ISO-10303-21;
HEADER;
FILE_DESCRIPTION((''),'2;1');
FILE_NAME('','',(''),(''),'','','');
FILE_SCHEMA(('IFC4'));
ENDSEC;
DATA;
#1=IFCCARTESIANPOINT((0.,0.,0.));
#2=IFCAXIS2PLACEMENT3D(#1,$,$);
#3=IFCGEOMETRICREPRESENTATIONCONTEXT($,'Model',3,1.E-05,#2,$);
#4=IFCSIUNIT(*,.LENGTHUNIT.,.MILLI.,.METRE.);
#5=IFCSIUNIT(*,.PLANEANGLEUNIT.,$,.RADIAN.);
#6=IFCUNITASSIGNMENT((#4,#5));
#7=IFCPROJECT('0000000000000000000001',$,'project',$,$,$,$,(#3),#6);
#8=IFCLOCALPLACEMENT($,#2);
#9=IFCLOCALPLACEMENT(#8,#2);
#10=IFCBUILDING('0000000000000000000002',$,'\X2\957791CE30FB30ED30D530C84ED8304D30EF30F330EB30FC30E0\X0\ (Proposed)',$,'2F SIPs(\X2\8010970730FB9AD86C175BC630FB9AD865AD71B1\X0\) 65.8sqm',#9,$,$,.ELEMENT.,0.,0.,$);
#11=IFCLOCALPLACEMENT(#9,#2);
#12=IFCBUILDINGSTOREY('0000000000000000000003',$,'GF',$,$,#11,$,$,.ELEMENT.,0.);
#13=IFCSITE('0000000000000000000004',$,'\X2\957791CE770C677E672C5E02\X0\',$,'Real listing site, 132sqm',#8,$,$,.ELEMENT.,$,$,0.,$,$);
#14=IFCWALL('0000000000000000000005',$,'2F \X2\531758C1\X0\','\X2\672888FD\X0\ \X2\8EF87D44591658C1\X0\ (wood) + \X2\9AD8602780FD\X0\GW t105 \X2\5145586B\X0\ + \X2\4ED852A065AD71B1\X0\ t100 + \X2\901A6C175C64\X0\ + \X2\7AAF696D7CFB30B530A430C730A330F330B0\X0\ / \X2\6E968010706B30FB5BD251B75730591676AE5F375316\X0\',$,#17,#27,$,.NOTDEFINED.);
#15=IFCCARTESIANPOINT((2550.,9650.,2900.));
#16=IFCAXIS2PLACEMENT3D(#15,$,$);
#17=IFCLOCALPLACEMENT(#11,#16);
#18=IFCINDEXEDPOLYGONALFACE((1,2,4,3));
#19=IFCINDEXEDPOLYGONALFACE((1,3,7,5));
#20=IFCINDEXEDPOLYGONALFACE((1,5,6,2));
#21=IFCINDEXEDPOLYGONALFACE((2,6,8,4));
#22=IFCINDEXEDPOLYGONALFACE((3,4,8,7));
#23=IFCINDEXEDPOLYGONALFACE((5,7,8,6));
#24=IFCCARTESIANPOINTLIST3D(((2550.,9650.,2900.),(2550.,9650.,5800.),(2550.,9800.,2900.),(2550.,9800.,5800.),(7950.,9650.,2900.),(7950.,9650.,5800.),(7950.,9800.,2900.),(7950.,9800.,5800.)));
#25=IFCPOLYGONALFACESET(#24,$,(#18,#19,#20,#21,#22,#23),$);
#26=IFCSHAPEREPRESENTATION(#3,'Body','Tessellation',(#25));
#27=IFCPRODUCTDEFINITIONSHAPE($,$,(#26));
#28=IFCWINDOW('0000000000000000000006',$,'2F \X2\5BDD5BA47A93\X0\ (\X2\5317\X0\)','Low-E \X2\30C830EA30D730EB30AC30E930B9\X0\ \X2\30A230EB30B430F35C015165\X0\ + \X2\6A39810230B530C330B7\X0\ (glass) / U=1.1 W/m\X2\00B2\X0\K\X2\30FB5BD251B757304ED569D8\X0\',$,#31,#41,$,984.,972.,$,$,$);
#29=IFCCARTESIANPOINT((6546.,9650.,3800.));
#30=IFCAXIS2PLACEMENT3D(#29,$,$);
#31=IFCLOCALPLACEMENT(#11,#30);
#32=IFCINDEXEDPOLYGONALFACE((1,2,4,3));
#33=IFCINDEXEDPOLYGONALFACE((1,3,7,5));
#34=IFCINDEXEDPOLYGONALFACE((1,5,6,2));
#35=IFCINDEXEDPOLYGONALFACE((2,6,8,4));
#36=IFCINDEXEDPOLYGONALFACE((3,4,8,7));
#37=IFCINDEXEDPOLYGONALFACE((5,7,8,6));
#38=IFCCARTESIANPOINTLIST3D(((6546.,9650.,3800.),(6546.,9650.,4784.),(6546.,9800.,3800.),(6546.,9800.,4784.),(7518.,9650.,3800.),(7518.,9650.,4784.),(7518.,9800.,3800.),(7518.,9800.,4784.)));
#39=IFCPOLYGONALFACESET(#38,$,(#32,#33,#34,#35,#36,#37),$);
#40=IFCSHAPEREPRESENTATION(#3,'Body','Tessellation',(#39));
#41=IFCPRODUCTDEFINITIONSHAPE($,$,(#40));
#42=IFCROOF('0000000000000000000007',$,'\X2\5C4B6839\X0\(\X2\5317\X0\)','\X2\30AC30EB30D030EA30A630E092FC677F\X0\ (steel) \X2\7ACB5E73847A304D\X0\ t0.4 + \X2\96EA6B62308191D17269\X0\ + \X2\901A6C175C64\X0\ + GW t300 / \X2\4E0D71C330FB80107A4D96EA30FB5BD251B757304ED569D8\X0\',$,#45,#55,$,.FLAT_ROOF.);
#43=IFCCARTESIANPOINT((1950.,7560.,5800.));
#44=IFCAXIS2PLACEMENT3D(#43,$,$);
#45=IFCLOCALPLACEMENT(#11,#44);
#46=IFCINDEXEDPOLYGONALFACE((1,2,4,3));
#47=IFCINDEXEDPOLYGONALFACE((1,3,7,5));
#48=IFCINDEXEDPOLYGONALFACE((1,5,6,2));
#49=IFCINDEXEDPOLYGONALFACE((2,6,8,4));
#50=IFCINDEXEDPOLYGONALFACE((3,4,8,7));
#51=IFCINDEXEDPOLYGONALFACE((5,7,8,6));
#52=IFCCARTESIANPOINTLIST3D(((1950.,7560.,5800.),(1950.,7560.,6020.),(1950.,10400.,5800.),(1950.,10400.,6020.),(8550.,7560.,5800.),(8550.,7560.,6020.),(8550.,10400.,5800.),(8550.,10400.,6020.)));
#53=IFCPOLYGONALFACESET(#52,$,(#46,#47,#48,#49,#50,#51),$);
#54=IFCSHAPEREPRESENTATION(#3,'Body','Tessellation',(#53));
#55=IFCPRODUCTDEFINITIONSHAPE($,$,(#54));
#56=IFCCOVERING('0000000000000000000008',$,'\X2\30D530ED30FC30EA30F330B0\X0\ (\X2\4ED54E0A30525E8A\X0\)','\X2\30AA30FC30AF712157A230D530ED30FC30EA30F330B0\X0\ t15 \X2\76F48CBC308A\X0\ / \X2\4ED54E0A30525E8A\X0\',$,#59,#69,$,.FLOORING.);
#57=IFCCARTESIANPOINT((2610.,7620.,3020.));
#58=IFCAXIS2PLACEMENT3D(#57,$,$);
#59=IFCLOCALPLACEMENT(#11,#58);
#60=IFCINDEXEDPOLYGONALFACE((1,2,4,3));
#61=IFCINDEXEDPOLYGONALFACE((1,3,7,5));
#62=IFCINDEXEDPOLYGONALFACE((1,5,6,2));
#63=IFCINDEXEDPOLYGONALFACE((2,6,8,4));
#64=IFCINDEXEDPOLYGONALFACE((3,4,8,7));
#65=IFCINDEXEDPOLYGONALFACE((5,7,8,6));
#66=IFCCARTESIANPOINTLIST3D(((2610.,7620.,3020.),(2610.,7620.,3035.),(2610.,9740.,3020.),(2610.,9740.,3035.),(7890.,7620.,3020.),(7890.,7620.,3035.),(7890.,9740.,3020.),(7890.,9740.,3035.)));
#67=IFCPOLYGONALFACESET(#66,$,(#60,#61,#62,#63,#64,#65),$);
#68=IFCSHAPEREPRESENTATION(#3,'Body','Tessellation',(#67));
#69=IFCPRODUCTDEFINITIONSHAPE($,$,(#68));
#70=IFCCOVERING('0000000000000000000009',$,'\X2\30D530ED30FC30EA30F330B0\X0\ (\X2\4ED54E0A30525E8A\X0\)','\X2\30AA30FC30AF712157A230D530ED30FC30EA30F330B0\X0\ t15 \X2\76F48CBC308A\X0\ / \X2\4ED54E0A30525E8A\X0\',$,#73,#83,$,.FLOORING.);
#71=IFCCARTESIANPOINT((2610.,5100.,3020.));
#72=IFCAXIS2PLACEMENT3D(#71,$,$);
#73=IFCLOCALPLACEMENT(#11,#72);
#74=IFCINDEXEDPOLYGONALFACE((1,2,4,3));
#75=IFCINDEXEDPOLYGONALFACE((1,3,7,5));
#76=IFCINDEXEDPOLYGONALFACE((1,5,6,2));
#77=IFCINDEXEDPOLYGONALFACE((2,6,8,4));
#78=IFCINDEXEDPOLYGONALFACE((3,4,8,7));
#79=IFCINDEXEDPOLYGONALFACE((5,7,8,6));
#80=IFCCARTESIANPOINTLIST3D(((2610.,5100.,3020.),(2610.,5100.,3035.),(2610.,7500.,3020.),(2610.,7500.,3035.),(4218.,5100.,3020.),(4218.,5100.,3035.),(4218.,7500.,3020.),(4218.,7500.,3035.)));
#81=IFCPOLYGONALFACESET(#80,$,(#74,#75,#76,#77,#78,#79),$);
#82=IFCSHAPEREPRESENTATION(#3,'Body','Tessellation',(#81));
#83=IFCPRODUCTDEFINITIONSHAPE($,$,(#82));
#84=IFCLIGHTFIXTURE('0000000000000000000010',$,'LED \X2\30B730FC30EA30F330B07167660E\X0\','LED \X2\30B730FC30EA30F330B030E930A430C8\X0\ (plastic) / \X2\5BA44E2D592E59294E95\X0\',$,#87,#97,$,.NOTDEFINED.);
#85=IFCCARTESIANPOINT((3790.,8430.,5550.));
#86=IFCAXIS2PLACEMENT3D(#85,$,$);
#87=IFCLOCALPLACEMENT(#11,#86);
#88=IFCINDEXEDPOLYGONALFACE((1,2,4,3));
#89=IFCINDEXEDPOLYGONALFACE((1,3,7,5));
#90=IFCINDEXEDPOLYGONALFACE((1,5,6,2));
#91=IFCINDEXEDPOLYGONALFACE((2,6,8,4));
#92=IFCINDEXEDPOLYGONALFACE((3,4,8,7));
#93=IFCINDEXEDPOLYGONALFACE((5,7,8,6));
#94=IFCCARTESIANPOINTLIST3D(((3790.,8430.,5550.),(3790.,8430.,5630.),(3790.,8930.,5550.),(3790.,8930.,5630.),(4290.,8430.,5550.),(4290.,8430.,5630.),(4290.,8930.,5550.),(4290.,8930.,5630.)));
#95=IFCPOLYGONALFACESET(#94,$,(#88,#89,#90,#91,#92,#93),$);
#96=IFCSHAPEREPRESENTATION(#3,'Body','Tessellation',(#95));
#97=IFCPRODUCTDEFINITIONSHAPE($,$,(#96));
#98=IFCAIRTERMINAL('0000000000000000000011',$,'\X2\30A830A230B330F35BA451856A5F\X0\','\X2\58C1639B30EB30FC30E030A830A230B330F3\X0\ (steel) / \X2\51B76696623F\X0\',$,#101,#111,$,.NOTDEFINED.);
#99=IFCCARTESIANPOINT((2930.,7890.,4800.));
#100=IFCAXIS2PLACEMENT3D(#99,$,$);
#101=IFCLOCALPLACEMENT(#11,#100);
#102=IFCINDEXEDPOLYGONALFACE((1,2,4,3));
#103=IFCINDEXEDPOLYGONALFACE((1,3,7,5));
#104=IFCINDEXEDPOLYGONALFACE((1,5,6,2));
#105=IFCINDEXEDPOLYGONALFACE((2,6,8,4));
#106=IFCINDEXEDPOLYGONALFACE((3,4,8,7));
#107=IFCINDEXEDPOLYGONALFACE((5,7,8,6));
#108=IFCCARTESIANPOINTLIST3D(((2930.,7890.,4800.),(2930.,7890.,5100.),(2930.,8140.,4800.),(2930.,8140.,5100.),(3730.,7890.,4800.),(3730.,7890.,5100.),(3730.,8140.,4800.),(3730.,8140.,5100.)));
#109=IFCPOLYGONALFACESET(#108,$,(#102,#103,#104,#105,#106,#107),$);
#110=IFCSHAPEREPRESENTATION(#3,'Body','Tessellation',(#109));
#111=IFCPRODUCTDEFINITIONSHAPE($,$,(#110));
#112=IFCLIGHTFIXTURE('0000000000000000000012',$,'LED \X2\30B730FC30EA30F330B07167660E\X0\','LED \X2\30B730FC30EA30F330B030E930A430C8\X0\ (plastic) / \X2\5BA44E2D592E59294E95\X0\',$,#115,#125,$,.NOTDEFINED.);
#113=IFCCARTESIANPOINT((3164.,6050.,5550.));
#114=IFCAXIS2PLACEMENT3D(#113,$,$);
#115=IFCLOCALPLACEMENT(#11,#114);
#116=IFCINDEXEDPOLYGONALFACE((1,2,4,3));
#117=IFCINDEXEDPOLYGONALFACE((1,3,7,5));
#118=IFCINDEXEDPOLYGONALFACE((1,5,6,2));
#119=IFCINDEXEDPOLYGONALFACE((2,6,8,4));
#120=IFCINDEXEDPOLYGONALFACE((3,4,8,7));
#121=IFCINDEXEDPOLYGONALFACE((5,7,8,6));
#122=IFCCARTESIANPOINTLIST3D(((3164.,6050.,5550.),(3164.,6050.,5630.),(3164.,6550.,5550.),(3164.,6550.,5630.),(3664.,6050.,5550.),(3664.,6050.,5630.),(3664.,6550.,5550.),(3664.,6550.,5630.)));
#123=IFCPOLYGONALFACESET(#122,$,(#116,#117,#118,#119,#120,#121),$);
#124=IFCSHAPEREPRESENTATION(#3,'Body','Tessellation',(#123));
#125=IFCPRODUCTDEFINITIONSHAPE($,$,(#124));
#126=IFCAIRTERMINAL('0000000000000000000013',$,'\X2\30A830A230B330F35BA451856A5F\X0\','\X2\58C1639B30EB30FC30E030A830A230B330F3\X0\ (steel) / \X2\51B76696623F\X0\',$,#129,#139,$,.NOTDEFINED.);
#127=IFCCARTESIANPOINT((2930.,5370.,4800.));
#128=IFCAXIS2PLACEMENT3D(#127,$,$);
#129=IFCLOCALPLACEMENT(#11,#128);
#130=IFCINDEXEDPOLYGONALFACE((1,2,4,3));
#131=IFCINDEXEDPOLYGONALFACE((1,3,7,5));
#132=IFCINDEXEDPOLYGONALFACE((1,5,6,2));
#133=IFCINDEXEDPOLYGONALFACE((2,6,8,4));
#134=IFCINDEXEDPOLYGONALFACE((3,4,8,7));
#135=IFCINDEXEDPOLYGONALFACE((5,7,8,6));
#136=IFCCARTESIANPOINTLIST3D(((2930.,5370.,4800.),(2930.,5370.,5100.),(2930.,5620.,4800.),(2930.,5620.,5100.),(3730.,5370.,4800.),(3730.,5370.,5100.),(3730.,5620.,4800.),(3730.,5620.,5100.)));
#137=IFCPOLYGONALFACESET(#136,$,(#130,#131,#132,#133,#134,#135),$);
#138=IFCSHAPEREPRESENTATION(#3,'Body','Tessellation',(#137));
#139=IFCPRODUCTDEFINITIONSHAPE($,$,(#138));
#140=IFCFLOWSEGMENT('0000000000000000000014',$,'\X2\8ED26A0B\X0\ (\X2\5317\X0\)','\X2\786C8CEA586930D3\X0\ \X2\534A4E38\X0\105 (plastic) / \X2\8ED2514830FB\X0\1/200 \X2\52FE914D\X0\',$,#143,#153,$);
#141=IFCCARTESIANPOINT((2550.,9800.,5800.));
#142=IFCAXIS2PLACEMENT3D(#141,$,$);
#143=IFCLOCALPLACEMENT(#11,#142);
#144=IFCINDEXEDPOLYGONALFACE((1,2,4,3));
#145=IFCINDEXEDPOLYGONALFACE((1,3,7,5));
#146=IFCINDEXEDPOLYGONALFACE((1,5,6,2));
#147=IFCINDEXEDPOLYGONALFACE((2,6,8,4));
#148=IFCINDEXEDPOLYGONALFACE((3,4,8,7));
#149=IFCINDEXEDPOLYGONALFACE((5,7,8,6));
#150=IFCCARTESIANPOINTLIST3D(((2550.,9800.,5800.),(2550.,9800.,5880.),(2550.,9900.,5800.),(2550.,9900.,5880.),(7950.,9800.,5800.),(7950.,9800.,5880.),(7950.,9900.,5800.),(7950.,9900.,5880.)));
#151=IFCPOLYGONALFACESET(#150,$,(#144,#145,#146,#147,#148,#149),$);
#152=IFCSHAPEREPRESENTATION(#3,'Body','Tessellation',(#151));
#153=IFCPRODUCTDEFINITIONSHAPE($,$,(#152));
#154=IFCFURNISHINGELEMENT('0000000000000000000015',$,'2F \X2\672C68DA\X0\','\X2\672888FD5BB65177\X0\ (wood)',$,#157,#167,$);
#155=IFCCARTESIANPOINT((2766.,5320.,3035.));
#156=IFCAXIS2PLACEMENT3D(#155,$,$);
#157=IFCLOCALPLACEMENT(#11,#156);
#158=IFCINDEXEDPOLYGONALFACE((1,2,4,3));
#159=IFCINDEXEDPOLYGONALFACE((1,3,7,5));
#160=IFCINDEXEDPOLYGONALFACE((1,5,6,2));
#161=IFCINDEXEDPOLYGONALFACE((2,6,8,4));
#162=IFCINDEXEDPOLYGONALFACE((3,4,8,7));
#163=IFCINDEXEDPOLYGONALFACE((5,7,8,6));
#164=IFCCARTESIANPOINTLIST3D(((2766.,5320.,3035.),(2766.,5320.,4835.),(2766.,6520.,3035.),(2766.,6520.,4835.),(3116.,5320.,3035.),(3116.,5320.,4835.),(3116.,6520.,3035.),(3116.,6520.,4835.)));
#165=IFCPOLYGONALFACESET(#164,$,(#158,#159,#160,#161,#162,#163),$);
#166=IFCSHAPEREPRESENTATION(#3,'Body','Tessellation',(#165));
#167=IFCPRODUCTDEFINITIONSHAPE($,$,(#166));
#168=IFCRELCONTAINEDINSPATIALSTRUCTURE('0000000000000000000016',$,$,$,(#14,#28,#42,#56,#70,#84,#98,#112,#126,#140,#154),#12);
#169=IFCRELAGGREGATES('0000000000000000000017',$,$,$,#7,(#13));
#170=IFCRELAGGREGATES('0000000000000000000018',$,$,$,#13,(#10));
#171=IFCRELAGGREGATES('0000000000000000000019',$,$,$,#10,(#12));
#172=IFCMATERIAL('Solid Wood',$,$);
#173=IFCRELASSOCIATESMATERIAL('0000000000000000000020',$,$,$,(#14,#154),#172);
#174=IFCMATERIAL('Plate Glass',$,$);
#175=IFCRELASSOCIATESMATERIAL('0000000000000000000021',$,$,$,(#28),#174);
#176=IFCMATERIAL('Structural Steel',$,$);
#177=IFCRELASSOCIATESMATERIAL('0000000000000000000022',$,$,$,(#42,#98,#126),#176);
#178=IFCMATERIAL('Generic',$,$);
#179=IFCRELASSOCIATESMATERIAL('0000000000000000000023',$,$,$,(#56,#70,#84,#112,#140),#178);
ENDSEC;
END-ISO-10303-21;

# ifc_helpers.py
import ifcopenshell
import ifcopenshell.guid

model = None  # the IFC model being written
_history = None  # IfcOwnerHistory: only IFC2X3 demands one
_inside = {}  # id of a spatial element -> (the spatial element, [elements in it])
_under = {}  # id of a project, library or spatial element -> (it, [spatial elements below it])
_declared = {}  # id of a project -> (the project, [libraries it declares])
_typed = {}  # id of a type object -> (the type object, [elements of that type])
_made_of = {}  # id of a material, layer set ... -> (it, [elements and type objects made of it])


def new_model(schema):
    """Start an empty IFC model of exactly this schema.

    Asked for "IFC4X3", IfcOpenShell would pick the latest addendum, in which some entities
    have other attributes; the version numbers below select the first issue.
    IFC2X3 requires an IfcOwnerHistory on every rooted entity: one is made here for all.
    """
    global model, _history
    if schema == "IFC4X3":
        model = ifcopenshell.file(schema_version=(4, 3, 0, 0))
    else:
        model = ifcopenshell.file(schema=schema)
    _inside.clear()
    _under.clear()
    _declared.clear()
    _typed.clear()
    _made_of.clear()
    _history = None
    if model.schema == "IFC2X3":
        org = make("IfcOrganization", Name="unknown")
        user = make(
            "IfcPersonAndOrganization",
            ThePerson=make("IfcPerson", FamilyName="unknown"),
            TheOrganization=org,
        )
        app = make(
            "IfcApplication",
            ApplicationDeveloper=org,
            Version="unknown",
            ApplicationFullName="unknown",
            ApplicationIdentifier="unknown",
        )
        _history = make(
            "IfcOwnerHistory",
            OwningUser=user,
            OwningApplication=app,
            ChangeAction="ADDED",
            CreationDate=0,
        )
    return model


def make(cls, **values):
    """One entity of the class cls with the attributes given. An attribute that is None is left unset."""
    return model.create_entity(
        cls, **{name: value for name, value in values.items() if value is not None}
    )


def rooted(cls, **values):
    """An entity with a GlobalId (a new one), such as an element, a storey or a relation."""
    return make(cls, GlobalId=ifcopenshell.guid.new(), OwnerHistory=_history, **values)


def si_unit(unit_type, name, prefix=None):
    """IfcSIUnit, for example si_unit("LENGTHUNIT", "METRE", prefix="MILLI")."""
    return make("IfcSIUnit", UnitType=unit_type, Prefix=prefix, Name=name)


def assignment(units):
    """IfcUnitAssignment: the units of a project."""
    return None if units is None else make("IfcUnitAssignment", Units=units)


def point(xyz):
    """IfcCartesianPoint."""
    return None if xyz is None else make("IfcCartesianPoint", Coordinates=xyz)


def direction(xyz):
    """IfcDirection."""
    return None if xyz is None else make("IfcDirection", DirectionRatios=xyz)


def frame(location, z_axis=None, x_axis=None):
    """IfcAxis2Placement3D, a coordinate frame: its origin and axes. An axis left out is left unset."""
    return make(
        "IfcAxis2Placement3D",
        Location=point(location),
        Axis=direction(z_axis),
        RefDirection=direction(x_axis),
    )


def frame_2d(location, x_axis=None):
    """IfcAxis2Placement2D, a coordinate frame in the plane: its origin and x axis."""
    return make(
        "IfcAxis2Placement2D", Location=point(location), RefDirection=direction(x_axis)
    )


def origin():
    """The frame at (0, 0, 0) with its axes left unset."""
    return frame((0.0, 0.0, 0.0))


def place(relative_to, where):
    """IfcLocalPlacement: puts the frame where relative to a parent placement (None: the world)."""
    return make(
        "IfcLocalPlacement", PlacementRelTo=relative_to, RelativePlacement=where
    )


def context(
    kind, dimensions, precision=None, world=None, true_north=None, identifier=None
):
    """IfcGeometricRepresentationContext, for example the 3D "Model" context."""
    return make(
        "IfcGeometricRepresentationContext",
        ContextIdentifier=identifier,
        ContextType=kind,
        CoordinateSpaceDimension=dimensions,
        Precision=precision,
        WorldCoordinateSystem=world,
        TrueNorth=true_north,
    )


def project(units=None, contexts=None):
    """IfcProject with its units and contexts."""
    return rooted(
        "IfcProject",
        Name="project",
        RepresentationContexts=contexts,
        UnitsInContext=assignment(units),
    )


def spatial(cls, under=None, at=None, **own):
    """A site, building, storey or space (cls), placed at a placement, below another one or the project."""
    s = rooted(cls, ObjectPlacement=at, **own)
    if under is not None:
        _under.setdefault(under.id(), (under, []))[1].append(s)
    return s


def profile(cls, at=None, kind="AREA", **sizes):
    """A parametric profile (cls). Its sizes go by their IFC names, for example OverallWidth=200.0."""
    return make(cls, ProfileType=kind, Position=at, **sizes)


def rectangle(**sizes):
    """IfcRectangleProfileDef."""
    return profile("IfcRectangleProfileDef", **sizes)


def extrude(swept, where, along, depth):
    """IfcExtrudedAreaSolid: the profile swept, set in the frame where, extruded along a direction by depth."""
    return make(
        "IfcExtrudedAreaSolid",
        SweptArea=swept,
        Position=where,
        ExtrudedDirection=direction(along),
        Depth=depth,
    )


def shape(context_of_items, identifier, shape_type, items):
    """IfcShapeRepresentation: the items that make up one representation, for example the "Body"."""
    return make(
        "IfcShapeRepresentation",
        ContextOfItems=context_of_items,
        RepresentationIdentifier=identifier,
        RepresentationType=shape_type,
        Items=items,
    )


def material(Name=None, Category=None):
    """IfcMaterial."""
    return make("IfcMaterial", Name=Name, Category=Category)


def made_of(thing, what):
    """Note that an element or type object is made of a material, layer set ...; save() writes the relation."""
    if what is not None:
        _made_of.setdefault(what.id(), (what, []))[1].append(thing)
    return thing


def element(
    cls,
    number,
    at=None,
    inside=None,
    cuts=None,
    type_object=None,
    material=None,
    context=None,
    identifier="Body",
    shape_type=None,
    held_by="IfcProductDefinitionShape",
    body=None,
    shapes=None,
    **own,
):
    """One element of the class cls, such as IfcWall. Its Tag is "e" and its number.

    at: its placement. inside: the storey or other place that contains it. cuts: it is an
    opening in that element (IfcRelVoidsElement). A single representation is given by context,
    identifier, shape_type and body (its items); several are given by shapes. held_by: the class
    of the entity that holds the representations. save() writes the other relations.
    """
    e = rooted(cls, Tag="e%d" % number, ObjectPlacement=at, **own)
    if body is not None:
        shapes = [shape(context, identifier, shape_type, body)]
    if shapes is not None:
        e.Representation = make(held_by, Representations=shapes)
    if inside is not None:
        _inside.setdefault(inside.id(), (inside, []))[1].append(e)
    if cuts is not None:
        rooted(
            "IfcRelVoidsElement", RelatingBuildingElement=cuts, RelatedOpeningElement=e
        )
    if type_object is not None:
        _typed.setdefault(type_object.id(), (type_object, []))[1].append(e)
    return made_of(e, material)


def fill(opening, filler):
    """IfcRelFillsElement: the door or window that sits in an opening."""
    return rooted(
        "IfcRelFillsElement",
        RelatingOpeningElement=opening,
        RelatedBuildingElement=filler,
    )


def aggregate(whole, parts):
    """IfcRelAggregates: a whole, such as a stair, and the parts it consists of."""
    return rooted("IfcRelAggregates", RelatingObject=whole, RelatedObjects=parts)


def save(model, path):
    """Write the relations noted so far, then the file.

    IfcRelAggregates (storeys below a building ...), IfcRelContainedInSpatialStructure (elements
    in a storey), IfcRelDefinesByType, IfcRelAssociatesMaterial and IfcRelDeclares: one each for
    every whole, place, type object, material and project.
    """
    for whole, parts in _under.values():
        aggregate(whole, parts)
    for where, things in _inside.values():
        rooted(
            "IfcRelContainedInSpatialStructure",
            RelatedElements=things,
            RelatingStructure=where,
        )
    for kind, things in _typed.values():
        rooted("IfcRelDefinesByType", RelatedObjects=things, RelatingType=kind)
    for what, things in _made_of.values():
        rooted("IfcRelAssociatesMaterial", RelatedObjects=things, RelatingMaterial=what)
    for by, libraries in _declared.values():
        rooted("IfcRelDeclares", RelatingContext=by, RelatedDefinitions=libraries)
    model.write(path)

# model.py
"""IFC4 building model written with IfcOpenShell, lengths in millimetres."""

from ifc_helpers import new_model, si_unit, frame, frame_2d, origin, place, context, project, spatial, rectangle, extrude, material, element, fill, save


model = new_model("IFC4")

# Units and contexts
model_context = context("Model", 3, precision=1e-05, world=origin())
ifc_project = project(units=[si_unit("LENGTHUNIT", "METRE", prefix="MILLI"), si_unit("PLANEANGLEUNIT", "RADIAN")], contexts=[model_context])

# Site, building, storey
site_placement = place(None, origin())
site = spatial("IfcSite", under=ifc_project, at=site_placement, Name="長野県松本市", ObjectType="Real listing site, 132sqm", CompositionType="ELEMENT", RefElevation=0.0)
building_placement = place(site_placement, origin())
building = spatial("IfcBuilding", under=site, at=building_placement, Name="長野・ロフト付きワンルーム (Proposed)", ObjectType="2F SIPs(耐震・高気密・高断熱) 65.8sqm", CompositionType="ELEMENT", ElevationOfRefHeight=0.0, ElevationOfTerrain=0.0)
storey_placement = place(building_placement, origin())
storey = spatial("IfcBuildingStorey", under=building, at=storey_placement, Name="GF", CompositionType="ELEMENT", Elevation=0.0)

# Shared definitions
ifc_material_1 = material(Name="Solid Wood")

# Wall, opening, window
wall_placement = place(storey_placement, frame((2550.0, 9650.0, 2900.0)))
wall = element("IfcWall", 1, at=wall_placement, inside=storey, material=ifc_material_1, Name="2F 北壁", Description="木製 軸組外壁 (wood) + 高性能GW t105 充填 + 付加断熱 t100 + 通気層 + 窯業系サイディング / 準耐火・寒冷地外皮強化", PredefinedType="NOTDEFINED", context=model_context, shape_type="SweptSolid", body=[
    extrude(rectangle(XDim=5400.0, YDim=150.0, at=frame_2d((2700.0, 75.0))), frame((2550.0, 9650.0, 2900.0)), (0.0, 0.0, 1.0), 2900.0),
])
opening_placement = place(storey_placement, frame((6546.0, 9650.0, 3800.0)))
opening = element("IfcOpeningElement", 2, at=opening_placement, cuts=wall, PredefinedType="NOTDEFINED", context=model_context, shape_type="SweptSolid", body=[
    extrude(rectangle(XDim=972.0, YDim=150.0, at=frame_2d((486.0, 75.0))), frame((6546.0, 9650.0, 3800.0)), (0.0, 0.0, 1.0), 984.0),
])
ifc_material_2 = material(Name="Plate Glass")
window_placement = place(storey_placement, frame((6546.0, 9650.0, 3800.0)))
window = element("IfcWindow", 3, at=window_placement, inside=storey, material=ifc_material_2, Name="2F 寝室窓 (北)", Description="Low-E トリプルガラス アルゴン封入 + 樹脂サッシ (glass) / U=1.1 W/m²K・寒冷地仕様", OverallHeight=984.0, OverallWidth=972.0, context=model_context, shape_type="SweptSolid", body=[
    extrude(rectangle(XDim=972.0, YDim=150.0, at=frame_2d((486.0, 75.0))), frame((6546.0, 9650.0, 3800.0)), (0.0, 0.0, 1.0), 984.0),
])
fill(opening, window)

# Roof
ifc_material_3 = material(Name="Structural Steel")
for number, where, name in (
    (4, (1950.0, 7560.0, 5800.0), "屋根(北)"),
):
    element("IfcRoof", number, at=place(storey_placement, frame(where)), inside=storey, material=ifc_material_3, Name=name, Description="ガルバリウム鋼板 (steel) 立平葺き t0.4 + 雪止め金物 + 通気層 + GW t300 / 不燃・耐積雪・寒冷地仕様", PredefinedType="FLAT_ROOF", context=model_context, shape_type="SweptSolid", body=[
        extrude(rectangle(XDim=6600.0, YDim=2840.0, at=frame_2d((3300.0, 1420.0))), frame((1950.0, 7560.0, 5800.0)), (0.0, 0.0, 1.0), 220.0),
    ])

# Coverings
ifc_material_4 = material(Name="Generic")
covering_1_placement = place(storey_placement, frame((2610.0, 7620.0, 3020.0)))
element("IfcCovering", 5, at=covering_1_placement, inside=storey, material=ifc_material_4, Name="フローリング (仕上げ床)", Description="オーク無垢フローリング t15 直貼り / 仕上げ床", PredefinedType="FLOORING", context=model_context, shape_type="SweptSolid", body=[
    extrude(rectangle(XDim=5280.0, YDim=2120.0, at=frame_2d((2640.0, 1060.0))), frame((2610.0, 7620.0, 3020.0)), (0.0, 0.0, 1.0), 15.0),
])
covering_2_placement = place(storey_placement, frame((2610.0, 5100.0, 3020.0)))
element("IfcCovering", 6, at=covering_2_placement, inside=storey, material=ifc_material_4, Name="フローリング (仕上げ床)", Description="オーク無垢フローリング t15 直貼り / 仕上げ床", PredefinedType="FLOORING", context=model_context, shape_type="SweptSolid", body=[
    extrude(rectangle(XDim=1608.0, YDim=2400.0, at=frame_2d((804.0, 1200.0))), frame((2610.0, 5100.0, 3020.0)), (0.0, 0.0, 1.0), 15.0),
])

# Light fixture
light_fixture_1_placement = place(storey_placement, frame((3790.0, 8430.0, 5550.0)))
element("IfcLightFixture", 7, at=light_fixture_1_placement, inside=storey, material=ifc_material_4, Name="LED シーリング照明", Description="LED シーリングライト (plastic) / 室中央天井", PredefinedType="NOTDEFINED", context=model_context, shape_type="SweptSolid", body=[
    extrude(rectangle(XDim=500.0, YDim=500.0, at=frame_2d((250.0, 250.0))), frame((3790.0, 8430.0, 5550.0)), (0.0, 0.0, 1.0), 80.0),
])

# Air terminal
air_terminal_1_placement = place(storey_placement, frame((2930.0, 7890.0, 4800.0)))
element("IfcAirTerminal", 8, at=air_terminal_1_placement, inside=storey, material=ifc_material_3, Name="エアコン室内機", Description="壁掛ルームエアコン (steel) / 冷暖房", PredefinedType="NOTDEFINED", context=model_context, shape_type="SweptSolid", body=[
    extrude(rectangle(XDim=800.0, YDim=250.0, at=frame_2d((400.0, 125.0))), frame((2930.0, 7890.0, 4800.0)), (0.0, 0.0, 1.0), 300.0),
])

# Light fixture
light_fixture_2_placement = place(storey_placement, frame((3164.0, 6050.0, 5550.0)))
element("IfcLightFixture", 9, at=light_fixture_2_placement, inside=storey, material=ifc_material_4, Name="LED シーリング照明", Description="LED シーリングライト (plastic) / 室中央天井", PredefinedType="NOTDEFINED", context=model_context, shape_type="SweptSolid", body=[
    extrude(rectangle(XDim=500.0, YDim=500.0, at=frame_2d((250.0, 250.0))), frame((3164.0, 6050.0, 5550.0)), (0.0, 0.0, 1.0), 80.0),
])

# Air terminal
air_terminal_2_placement = place(storey_placement, frame((2930.0, 5370.0, 4800.0)))
element("IfcAirTerminal", 10, at=air_terminal_2_placement, inside=storey, material=ifc_material_3, Name="エアコン室内機", Description="壁掛ルームエアコン (steel) / 冷暖房", PredefinedType="NOTDEFINED", context=model_context, shape_type="SweptSolid", body=[
    extrude(rectangle(XDim=800.0, YDim=250.0, at=frame_2d((400.0, 125.0))), frame((2930.0, 5370.0, 4800.0)), (0.0, 0.0, 1.0), 300.0),
])

# Flow segment
flow_segment_placement = place(storey_placement, frame((2550.0, 9800.0, 5800.0)))
element("IfcFlowSegment", 11, at=flow_segment_placement, inside=storey, material=ifc_material_4, Name="軒樋 (北)", Description="硬質塩ビ 半丸105 (plastic) / 軒先・1/200 勾配", context=model_context, shape_type="SweptSolid", body=[
    extrude(rectangle(XDim=5400.0, YDim=100.0, at=frame_2d((2700.0, 50.0))), frame((2550.0, 9800.0, 5800.0)), (0.0, 0.0, 1.0), 80.0),
])

# Furnishing element
furnishing_placement = place(storey_placement, frame((2766.0, 5320.0, 3035.0)))
element("IfcFurnishingElement", 12, at=furnishing_placement, inside=storey, material=ifc_material_1, Name="2F 本棚", Description="木製家具 (wood)", context=model_context, shape_type="SweptSolid", body=[
    extrude(rectangle(XDim=350.0, YDim=1200.0, at=frame_2d((175.0, 600.0))), frame((2766.0, 5320.0, 3035.0)), (0.0, 0.0, 1.0), 1800.0),
])

save(model, "model.ifc")
